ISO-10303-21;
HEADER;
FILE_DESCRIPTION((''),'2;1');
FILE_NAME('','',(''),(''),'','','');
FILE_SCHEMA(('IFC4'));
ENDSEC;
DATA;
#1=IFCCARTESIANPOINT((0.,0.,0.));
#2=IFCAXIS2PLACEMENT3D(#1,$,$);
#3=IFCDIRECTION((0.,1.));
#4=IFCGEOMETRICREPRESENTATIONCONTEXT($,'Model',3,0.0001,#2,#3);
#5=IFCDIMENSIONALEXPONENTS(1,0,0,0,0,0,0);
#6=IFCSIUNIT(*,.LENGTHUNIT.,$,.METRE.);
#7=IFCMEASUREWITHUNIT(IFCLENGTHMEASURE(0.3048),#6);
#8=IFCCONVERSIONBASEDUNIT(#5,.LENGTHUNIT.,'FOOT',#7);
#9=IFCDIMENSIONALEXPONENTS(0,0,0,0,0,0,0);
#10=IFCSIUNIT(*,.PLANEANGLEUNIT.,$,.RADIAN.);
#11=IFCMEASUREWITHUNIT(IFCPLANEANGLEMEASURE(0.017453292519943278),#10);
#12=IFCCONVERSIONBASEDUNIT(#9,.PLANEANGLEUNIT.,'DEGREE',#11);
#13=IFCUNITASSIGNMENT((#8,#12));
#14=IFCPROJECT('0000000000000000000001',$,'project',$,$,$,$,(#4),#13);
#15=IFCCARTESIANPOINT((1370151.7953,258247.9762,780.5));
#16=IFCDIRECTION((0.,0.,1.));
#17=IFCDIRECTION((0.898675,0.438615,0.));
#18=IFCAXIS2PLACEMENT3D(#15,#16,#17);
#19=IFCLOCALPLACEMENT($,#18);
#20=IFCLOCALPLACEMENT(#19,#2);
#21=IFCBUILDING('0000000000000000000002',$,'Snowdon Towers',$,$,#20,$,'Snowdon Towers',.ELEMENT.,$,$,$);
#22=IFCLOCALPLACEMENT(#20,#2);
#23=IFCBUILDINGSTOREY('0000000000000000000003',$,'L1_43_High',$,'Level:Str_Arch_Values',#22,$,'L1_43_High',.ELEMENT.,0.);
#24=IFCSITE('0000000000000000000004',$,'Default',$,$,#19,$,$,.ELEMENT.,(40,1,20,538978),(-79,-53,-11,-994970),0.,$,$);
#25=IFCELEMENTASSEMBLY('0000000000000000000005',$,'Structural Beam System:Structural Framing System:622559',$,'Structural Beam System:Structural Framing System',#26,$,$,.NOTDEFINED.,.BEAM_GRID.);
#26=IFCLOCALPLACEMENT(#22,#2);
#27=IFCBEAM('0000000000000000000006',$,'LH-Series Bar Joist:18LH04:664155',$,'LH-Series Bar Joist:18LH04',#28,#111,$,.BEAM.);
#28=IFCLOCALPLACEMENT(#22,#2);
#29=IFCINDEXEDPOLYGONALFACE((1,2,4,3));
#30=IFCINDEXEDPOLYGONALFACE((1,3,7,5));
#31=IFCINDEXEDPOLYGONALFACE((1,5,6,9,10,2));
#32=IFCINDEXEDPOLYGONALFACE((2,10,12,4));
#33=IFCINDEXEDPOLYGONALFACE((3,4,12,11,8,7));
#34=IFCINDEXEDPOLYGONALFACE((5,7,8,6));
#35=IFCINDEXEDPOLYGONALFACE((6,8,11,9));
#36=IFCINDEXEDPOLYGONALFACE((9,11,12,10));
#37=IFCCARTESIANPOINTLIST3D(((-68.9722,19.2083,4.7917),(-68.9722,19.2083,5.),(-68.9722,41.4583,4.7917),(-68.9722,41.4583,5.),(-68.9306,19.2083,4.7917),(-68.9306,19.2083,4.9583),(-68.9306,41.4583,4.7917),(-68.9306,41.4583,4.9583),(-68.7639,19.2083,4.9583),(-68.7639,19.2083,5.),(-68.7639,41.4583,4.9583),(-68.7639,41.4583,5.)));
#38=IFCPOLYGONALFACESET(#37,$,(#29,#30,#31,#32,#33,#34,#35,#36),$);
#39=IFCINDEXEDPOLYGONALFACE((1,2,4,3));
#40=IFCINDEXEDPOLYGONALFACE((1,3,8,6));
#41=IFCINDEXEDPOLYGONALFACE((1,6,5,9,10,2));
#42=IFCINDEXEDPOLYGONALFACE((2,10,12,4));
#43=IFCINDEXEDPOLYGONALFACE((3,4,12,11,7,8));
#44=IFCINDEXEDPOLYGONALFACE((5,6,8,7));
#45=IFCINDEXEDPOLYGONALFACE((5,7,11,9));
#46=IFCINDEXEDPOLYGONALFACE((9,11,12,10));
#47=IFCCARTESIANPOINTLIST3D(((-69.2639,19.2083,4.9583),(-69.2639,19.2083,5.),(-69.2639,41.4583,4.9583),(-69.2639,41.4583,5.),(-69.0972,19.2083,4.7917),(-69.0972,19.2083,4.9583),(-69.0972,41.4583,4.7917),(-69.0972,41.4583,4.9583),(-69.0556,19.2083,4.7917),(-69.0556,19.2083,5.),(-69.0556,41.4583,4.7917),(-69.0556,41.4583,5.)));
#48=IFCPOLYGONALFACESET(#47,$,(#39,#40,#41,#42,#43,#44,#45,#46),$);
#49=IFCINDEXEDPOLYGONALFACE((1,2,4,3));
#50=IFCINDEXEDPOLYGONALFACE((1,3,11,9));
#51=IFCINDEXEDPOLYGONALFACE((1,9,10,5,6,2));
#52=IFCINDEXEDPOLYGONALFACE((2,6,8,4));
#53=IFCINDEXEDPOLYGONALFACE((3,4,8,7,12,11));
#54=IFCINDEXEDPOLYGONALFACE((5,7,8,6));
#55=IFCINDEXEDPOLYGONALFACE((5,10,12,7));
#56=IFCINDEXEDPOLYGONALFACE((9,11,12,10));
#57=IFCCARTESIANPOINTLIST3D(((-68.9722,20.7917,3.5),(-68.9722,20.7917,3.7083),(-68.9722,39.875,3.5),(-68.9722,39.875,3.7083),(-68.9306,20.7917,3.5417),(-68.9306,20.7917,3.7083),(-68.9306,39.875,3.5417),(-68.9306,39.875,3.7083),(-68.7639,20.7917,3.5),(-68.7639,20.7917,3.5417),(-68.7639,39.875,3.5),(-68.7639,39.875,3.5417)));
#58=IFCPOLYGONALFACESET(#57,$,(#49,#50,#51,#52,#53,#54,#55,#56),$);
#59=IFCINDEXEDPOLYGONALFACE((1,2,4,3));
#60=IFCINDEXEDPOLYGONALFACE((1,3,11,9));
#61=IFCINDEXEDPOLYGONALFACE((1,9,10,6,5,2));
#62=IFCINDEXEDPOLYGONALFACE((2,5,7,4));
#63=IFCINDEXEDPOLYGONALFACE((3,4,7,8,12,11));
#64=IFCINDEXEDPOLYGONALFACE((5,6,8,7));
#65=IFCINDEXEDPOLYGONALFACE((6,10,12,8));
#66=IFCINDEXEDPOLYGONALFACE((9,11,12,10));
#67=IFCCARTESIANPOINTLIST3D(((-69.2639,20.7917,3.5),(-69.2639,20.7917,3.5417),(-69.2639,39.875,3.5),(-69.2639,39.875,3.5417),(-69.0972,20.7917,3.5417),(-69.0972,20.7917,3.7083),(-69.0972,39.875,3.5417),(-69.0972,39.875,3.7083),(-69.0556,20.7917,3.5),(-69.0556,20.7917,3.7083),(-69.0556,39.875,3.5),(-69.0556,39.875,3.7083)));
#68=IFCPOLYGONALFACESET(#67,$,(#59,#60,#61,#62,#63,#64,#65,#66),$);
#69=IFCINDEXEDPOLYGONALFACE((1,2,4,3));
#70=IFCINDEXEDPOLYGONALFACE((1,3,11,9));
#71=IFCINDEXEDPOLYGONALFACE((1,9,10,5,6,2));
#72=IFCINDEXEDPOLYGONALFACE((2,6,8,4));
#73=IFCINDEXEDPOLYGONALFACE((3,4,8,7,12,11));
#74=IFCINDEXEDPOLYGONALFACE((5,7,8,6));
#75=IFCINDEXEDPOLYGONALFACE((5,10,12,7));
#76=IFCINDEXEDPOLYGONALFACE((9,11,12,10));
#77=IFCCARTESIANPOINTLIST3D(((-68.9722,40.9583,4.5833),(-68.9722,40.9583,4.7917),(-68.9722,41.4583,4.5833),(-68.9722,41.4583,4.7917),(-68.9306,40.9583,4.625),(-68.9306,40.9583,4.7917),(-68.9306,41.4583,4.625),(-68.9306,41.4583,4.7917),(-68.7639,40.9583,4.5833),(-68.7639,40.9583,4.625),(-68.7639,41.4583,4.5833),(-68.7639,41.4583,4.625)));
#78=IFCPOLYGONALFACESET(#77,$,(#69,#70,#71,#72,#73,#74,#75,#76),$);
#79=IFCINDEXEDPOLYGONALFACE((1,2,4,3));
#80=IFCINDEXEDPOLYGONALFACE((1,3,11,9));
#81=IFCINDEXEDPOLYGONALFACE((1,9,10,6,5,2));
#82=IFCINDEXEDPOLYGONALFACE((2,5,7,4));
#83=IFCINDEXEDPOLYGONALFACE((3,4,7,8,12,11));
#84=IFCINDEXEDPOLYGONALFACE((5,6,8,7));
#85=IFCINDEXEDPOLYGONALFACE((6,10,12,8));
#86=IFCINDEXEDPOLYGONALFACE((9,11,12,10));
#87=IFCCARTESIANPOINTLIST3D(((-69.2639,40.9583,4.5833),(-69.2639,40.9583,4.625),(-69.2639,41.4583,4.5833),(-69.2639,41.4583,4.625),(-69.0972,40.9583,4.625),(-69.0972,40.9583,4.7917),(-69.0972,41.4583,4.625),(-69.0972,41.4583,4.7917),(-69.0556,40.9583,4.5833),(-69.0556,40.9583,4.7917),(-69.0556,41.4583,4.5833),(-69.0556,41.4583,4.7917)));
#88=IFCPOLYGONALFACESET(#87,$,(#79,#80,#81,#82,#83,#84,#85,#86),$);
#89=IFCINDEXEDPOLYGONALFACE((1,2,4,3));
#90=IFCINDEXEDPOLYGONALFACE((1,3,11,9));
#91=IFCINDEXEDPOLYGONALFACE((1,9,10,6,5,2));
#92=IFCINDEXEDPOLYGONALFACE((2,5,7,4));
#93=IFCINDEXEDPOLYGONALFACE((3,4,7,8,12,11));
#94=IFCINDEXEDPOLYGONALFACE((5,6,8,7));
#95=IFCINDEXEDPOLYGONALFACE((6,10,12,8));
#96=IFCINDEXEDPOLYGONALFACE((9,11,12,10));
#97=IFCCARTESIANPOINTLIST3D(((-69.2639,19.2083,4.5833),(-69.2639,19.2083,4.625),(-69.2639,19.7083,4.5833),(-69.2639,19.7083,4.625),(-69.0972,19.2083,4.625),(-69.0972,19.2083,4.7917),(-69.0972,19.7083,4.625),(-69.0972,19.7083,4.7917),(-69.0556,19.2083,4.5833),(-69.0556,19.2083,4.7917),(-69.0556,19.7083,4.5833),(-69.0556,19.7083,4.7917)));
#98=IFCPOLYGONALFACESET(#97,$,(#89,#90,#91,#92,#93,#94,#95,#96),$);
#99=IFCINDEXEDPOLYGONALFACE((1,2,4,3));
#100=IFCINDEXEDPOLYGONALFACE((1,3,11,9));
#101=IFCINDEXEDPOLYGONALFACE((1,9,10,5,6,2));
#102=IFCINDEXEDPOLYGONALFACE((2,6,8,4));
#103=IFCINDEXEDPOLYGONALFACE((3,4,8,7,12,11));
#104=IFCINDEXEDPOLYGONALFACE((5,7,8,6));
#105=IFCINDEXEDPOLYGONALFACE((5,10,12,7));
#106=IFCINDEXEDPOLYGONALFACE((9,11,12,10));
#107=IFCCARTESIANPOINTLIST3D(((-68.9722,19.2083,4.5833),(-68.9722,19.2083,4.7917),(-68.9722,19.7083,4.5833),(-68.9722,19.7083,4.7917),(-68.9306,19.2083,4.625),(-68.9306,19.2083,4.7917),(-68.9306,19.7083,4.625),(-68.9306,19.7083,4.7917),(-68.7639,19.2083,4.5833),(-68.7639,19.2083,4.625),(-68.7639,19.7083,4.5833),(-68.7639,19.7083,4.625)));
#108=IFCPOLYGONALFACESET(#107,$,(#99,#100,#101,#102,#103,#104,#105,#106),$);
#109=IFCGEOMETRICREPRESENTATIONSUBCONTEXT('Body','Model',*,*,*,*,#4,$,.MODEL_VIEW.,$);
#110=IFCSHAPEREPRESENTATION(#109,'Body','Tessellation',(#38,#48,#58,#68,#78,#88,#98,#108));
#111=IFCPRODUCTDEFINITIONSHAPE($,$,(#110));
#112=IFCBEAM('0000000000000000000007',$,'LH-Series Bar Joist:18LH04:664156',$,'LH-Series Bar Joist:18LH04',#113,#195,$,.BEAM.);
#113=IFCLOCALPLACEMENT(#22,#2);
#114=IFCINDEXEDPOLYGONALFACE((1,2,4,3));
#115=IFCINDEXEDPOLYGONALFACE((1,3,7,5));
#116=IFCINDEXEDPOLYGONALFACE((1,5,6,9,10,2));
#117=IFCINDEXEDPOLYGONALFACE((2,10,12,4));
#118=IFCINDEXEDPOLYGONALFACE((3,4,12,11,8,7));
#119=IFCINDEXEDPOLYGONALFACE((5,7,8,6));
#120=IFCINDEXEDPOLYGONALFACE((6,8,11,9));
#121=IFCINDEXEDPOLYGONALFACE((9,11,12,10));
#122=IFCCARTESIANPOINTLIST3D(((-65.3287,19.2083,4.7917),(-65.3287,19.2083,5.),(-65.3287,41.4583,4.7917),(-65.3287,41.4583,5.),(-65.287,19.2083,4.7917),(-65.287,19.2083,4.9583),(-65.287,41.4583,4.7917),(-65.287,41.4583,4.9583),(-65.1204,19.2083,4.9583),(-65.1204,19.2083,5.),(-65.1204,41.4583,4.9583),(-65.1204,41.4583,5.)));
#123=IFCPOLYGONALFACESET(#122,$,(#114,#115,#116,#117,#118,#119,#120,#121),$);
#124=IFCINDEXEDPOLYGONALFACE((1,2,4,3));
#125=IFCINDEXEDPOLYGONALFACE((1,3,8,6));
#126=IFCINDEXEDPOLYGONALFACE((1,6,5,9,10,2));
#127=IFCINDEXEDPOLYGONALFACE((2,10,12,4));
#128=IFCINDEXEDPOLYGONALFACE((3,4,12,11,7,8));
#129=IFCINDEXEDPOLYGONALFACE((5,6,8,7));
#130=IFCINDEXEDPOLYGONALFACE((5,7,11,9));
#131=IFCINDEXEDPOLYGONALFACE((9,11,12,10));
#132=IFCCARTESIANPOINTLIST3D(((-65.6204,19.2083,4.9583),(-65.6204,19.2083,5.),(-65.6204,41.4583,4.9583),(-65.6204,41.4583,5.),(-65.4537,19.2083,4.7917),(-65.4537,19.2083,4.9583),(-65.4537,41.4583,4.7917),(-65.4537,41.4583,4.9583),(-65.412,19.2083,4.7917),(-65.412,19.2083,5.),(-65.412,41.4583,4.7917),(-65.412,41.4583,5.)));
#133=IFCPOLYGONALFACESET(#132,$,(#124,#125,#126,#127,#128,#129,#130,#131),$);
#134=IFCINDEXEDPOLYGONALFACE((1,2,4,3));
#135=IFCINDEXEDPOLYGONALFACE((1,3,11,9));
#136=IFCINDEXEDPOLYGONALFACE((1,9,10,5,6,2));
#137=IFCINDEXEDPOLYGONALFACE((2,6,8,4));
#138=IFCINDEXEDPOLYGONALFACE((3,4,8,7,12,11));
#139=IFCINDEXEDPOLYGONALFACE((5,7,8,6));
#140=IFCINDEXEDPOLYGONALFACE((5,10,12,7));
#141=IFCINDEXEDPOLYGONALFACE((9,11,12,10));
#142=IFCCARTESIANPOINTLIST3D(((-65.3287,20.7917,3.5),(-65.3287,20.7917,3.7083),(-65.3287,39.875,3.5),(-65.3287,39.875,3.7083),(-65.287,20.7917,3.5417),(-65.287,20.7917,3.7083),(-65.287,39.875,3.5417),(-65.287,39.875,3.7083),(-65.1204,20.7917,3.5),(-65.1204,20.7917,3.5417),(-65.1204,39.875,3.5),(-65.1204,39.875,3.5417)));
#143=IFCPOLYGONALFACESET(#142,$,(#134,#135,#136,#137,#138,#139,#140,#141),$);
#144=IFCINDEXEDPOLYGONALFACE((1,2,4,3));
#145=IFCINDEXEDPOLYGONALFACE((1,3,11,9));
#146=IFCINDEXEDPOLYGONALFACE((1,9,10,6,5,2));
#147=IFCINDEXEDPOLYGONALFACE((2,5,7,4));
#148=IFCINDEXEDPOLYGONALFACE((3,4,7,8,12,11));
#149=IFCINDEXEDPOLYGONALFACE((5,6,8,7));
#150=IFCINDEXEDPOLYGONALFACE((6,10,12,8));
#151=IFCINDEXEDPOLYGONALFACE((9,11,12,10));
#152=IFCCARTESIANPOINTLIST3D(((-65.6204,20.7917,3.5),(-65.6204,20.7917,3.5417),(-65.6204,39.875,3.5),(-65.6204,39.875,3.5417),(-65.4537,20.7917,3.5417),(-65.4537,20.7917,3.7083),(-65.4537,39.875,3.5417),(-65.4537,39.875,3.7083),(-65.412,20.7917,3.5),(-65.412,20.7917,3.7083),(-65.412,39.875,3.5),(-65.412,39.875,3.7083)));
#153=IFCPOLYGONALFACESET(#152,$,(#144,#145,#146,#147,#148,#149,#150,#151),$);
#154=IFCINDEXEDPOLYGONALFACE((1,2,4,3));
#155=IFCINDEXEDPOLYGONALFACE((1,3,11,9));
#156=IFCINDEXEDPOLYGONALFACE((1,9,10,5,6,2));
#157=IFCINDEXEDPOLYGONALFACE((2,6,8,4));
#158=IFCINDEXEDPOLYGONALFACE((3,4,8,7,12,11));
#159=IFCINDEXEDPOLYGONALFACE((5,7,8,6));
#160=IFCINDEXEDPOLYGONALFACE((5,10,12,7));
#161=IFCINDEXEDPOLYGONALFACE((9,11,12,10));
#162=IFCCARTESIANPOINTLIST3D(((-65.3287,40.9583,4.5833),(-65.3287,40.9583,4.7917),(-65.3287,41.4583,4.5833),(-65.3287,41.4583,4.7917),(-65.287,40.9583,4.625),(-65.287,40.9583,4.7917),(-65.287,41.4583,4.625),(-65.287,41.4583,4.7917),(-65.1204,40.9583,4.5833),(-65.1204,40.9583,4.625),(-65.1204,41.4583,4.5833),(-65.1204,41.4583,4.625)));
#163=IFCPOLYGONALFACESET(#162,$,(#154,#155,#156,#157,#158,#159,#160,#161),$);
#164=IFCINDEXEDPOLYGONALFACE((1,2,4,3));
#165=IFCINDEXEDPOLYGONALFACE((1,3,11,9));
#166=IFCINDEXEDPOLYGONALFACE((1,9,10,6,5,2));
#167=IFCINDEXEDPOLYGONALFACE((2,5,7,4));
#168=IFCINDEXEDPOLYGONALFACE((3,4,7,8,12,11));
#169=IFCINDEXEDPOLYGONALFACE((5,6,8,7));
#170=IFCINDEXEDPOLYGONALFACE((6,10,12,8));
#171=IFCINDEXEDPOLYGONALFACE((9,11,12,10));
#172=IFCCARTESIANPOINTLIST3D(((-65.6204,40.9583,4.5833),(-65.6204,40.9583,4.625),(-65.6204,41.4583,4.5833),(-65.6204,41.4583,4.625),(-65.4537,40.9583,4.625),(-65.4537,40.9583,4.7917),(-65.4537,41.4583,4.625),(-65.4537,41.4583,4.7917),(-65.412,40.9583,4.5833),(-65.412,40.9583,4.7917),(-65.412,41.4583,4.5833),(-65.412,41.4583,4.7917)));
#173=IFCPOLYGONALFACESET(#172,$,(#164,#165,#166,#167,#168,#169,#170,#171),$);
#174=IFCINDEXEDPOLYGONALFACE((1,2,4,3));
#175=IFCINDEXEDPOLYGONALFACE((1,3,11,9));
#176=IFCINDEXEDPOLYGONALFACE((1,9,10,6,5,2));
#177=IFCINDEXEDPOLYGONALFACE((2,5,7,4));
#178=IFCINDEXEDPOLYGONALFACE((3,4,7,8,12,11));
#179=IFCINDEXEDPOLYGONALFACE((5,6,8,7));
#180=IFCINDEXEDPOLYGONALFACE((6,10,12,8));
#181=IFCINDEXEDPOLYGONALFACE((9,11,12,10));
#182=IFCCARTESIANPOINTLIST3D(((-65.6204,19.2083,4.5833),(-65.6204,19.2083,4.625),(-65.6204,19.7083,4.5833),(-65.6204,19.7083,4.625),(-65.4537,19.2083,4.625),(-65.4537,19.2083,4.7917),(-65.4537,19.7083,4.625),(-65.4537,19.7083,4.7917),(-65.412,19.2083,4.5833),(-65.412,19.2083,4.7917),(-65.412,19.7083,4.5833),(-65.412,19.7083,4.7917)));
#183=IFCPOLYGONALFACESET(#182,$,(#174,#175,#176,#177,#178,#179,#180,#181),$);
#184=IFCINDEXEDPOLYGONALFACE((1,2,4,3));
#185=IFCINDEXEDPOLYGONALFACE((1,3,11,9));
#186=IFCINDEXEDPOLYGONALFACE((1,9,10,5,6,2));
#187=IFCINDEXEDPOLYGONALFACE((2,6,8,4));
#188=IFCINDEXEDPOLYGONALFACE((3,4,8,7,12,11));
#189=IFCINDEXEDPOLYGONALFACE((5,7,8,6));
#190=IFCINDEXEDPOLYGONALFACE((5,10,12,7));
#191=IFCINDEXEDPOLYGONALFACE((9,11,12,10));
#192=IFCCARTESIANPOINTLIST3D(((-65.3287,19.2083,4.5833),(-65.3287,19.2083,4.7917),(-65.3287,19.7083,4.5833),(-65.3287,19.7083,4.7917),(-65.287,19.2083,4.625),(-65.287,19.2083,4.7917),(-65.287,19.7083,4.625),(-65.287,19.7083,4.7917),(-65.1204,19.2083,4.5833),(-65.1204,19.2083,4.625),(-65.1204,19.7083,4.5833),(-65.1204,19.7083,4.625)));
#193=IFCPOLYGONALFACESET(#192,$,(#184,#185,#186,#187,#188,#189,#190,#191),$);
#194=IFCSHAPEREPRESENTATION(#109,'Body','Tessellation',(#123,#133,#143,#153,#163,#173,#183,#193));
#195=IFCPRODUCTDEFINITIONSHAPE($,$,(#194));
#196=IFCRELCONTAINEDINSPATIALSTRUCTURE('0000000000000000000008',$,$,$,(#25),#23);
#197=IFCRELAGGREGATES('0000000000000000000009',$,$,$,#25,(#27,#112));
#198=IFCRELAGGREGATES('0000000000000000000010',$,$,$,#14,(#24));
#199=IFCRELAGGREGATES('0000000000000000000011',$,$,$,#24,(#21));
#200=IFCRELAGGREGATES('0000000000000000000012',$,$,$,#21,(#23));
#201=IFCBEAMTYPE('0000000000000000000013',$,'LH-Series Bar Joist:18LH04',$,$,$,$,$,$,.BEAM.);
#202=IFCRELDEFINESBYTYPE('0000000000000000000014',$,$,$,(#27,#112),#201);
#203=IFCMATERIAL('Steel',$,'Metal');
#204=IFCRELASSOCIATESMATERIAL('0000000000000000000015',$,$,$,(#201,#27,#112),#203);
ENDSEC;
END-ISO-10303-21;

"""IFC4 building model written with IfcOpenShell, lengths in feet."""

from ifc_helpers import new_model, entity, si_unit, converted_unit, direction, frame, origin, place, context, subcontext, project, spatial, indexed_curve, outline, extrude, source, transform, mapped, material, type_object, type_shapes, element, aggregate, save


model = new_model("IFC4")

# Units and contexts
model_context = context("Model", 3, precision=0.0001, world=origin(), true_north=direction((0.0, 1.0)))
body_context = subcontext(model_context, "Body", "Model", "MODEL_VIEW")
ifc_project = project(units=[converted_unit("LENGTHUNIT", "FOOT", entity("IfcLengthMeasure", 0.3048), si_unit("LENGTHUNIT", "METRE"), dimensions=[1, 0, 0, 0, 0, 0, 0]), converted_unit("PLANEANGLEUNIT", "DEGREE", entity("IfcPlaneAngleMeasure", 0.017453292519943278), si_unit("PLANEANGLEUNIT", "RADIAN"), dimensions=[0, 0, 0, 0, 0, 0, 0])], contexts=[model_context])

# Site, building, storey
site_placement = place(None, frame((1370151.7953, 258247.9762, 780.5), z_axis=(0.0, 0.0, 1.0), x_axis=(0.898675, 0.438615, 0.0)))
site = spatial("IfcSite", under=ifc_project, at=site_placement, Name="Default", CompositionType="ELEMENT", RefLatitude=(40, 1, 20, 538978), RefLongitude=(-79, -53, -11, -994970), RefElevation=0.0)
building_placement = place(site_placement, origin())
building = spatial("IfcBuilding", under=site, at=building_placement, Name="Snowdon Towers", LongName="Snowdon Towers", CompositionType="ELEMENT")
storey_placement = place(building_placement, origin())
storey = spatial("IfcBuildingStorey", under=building, at=storey_placement, Name="L1_43_High", ObjectType="Level:Str_Arch_Values", LongName="L1_43_High", CompositionType="ELEMENT", Elevation=0.0)

# Shared definitions
ifc_material_1 = material(Name="Steel", Category="Metal")

# Element assembly, beams
assembly_placement = place(storey_placement, origin())
assembly = element("IfcElementAssembly", 1, at=assembly_placement, inside=storey, Name="Structural Beam System:Structural Framing System:622559", ObjectType="Structural Beam System:Structural Framing System", AssemblyPlace="NOTDEFINED", PredefinedType="BEAM_GRID")
beam_type_1 = type_object("IfcBeamType", Name="LH-Series Bar Joist:18LH04", PredefinedType="BEAM", material=ifc_material_1)
shared_shape_1 = source(origin(), body_context, "Body", "SweptSolid", [
    extrude(outline(indexed_curve([(-0.0833, -0.0833), (0.125, -0.0833), (0.125, -0.0417), (-0.0417, -0.0417), (-0.0417, 0.125), (-0.0833, 0.125), (-0.0833, -0.0833)], self_intersect=False)), frame((-11.125, -0.125, 0.6667), z_axis=(1.0, 0.0, 0.0), x_axis=(0.0, -1.0, 0.0)), (0.0, 0.0, 1.0), 22.25),
    extrude(outline(indexed_curve([(-0.0833, -0.0833), (0.125, -0.0833), (0.125, -0.0417), (-0.0417, -0.0417), (-0.0417, 0.125), (-0.0833, 0.125), (-0.0833, -0.0833)], self_intersect=False)), frame((-11.125, 0.125, 0.6667), z_axis=(1.0, 0.0, 0.0), x_axis=(0.0, 0.0, -1.0)), (0.0, 0.0, 1.0), 22.25),
    extrude(outline(indexed_curve([(-0.0833, -0.0833), (0.125, -0.0833), (0.125, -0.0417), (-0.0417, -0.0417), (-0.0417, 0.125), (-0.0833, 0.125), (-0.0833, -0.0833)], self_intersect=False)), frame((-9.5417, -0.125, -0.6667), z_axis=(1.0, 0.0, 0.0), x_axis=(0.0, 0.0, 1.0)), (0.0, 0.0, 1.0), 19.0833),
    extrude(outline(indexed_curve([(-0.0833, -0.0833), (0.125, -0.0833), (0.125, -0.0417), (-0.0417, -0.0417), (-0.0417, 0.125), (-0.0833, 0.125), (-0.0833, -0.0833)], self_intersect=False)), frame((-9.5417, 0.125, -0.6667), z_axis=(1.0, 0.0, 0.0), x_axis=(0.0, 1.0, 0.0)), (0.0, 0.0, 1.0), 19.0833),
    extrude(outline(indexed_curve([(-0.0833, -0.0833), (0.125, -0.0833), (0.125, -0.0417), (-0.0417, -0.0417), (-0.0417, 0.125), (-0.0833, 0.125), (-0.0833, -0.0833)], self_intersect=False)), frame((10.625, -0.125, 0.4167), z_axis=(1.0, 0.0, 0.0), x_axis=(0.0, 0.0, 1.0)), (0.0, 0.0, 1.0), 0.5),
    extrude(outline(indexed_curve([(-0.0833, -0.0833), (0.125, -0.0833), (0.125, -0.0417), (-0.0417, -0.0417), (-0.0417, 0.125), (-0.0833, 0.125), (-0.0833, -0.0833)], self_intersect=False)), frame((10.625, 0.125, 0.4167), z_axis=(1.0, 0.0, 0.0), x_axis=(0.0, 1.0, 0.0)), (0.0, 0.0, 1.0), 0.5),
    extrude(outline(indexed_curve([(-0.0833, -0.125), (-0.0417, -0.125), (-0.0417, 0.0417), (0.125, 0.0417), (0.125, 0.0833), (-0.0833, 0.0833), (-0.0833, -0.125)], self_intersect=False)), frame((-11.125, 0.125, 0.4167), z_axis=(1.0, 0.0, 0.0), x_axis=(0.0, 0.0, 1.0)), (0.0, 0.0, 1.0), 0.5),
    extrude(outline(indexed_curve([(-0.0833, -0.0833), (0.125, -0.0833), (0.125, -0.0417), (-0.0417, -0.0417), (-0.0417, 0.125), (-0.0833, 0.125), (-0.0833, -0.0833)], self_intersect=False)), frame((-11.125, -0.125, 0.4167), z_axis=(1.0, 0.0, 0.0), x_axis=(0.0, 0.0, 1.0)), (0.0, 0.0, 1.0), 0.5),
])
type_shapes(beam_type_1, [shared_shape_1])
beam_1_placement = place(assembly_placement, frame((-69.0139, 30.3333, 4.25), z_axis=(0.0, 0.0, 1.0), x_axis=(0.0, 1.0, 0.0)))
beam_1 = element("IfcBeam", 2, at=beam_1_placement, type_object=beam_type_1, material=ifc_material_1, Name="LH-Series Bar Joist:18LH04:664155", ObjectType="LH-Series Bar Joist:18LH04", PredefinedType="BEAM", context=body_context, shape_type="MappedRepresentation", body=[
    mapped(shared_shape_1, transform((0.0, 0.0, 0.0), scale=1.0)),
])
beam_2_placement = place(assembly_placement, frame((-65.3704, 30.3333, 4.25), z_axis=(0.0, 0.0, 1.0), x_axis=(0.0, 1.0, 0.0)))
beam_2 = element("IfcBeam", 3, at=beam_2_placement, type_object=beam_type_1, material=ifc_material_1, Name="LH-Series Bar Joist:18LH04:664156", ObjectType="LH-Series Bar Joist:18LH04", PredefinedType="BEAM", context=body_context, shape_type="MappedRepresentation", body=[
    mapped(shared_shape_1, transform((0.0, 0.0, 0.0), scale=1.0)),
])
aggregate(assembly, [beam_1, beam_2])

save(model, "model.ifc")
